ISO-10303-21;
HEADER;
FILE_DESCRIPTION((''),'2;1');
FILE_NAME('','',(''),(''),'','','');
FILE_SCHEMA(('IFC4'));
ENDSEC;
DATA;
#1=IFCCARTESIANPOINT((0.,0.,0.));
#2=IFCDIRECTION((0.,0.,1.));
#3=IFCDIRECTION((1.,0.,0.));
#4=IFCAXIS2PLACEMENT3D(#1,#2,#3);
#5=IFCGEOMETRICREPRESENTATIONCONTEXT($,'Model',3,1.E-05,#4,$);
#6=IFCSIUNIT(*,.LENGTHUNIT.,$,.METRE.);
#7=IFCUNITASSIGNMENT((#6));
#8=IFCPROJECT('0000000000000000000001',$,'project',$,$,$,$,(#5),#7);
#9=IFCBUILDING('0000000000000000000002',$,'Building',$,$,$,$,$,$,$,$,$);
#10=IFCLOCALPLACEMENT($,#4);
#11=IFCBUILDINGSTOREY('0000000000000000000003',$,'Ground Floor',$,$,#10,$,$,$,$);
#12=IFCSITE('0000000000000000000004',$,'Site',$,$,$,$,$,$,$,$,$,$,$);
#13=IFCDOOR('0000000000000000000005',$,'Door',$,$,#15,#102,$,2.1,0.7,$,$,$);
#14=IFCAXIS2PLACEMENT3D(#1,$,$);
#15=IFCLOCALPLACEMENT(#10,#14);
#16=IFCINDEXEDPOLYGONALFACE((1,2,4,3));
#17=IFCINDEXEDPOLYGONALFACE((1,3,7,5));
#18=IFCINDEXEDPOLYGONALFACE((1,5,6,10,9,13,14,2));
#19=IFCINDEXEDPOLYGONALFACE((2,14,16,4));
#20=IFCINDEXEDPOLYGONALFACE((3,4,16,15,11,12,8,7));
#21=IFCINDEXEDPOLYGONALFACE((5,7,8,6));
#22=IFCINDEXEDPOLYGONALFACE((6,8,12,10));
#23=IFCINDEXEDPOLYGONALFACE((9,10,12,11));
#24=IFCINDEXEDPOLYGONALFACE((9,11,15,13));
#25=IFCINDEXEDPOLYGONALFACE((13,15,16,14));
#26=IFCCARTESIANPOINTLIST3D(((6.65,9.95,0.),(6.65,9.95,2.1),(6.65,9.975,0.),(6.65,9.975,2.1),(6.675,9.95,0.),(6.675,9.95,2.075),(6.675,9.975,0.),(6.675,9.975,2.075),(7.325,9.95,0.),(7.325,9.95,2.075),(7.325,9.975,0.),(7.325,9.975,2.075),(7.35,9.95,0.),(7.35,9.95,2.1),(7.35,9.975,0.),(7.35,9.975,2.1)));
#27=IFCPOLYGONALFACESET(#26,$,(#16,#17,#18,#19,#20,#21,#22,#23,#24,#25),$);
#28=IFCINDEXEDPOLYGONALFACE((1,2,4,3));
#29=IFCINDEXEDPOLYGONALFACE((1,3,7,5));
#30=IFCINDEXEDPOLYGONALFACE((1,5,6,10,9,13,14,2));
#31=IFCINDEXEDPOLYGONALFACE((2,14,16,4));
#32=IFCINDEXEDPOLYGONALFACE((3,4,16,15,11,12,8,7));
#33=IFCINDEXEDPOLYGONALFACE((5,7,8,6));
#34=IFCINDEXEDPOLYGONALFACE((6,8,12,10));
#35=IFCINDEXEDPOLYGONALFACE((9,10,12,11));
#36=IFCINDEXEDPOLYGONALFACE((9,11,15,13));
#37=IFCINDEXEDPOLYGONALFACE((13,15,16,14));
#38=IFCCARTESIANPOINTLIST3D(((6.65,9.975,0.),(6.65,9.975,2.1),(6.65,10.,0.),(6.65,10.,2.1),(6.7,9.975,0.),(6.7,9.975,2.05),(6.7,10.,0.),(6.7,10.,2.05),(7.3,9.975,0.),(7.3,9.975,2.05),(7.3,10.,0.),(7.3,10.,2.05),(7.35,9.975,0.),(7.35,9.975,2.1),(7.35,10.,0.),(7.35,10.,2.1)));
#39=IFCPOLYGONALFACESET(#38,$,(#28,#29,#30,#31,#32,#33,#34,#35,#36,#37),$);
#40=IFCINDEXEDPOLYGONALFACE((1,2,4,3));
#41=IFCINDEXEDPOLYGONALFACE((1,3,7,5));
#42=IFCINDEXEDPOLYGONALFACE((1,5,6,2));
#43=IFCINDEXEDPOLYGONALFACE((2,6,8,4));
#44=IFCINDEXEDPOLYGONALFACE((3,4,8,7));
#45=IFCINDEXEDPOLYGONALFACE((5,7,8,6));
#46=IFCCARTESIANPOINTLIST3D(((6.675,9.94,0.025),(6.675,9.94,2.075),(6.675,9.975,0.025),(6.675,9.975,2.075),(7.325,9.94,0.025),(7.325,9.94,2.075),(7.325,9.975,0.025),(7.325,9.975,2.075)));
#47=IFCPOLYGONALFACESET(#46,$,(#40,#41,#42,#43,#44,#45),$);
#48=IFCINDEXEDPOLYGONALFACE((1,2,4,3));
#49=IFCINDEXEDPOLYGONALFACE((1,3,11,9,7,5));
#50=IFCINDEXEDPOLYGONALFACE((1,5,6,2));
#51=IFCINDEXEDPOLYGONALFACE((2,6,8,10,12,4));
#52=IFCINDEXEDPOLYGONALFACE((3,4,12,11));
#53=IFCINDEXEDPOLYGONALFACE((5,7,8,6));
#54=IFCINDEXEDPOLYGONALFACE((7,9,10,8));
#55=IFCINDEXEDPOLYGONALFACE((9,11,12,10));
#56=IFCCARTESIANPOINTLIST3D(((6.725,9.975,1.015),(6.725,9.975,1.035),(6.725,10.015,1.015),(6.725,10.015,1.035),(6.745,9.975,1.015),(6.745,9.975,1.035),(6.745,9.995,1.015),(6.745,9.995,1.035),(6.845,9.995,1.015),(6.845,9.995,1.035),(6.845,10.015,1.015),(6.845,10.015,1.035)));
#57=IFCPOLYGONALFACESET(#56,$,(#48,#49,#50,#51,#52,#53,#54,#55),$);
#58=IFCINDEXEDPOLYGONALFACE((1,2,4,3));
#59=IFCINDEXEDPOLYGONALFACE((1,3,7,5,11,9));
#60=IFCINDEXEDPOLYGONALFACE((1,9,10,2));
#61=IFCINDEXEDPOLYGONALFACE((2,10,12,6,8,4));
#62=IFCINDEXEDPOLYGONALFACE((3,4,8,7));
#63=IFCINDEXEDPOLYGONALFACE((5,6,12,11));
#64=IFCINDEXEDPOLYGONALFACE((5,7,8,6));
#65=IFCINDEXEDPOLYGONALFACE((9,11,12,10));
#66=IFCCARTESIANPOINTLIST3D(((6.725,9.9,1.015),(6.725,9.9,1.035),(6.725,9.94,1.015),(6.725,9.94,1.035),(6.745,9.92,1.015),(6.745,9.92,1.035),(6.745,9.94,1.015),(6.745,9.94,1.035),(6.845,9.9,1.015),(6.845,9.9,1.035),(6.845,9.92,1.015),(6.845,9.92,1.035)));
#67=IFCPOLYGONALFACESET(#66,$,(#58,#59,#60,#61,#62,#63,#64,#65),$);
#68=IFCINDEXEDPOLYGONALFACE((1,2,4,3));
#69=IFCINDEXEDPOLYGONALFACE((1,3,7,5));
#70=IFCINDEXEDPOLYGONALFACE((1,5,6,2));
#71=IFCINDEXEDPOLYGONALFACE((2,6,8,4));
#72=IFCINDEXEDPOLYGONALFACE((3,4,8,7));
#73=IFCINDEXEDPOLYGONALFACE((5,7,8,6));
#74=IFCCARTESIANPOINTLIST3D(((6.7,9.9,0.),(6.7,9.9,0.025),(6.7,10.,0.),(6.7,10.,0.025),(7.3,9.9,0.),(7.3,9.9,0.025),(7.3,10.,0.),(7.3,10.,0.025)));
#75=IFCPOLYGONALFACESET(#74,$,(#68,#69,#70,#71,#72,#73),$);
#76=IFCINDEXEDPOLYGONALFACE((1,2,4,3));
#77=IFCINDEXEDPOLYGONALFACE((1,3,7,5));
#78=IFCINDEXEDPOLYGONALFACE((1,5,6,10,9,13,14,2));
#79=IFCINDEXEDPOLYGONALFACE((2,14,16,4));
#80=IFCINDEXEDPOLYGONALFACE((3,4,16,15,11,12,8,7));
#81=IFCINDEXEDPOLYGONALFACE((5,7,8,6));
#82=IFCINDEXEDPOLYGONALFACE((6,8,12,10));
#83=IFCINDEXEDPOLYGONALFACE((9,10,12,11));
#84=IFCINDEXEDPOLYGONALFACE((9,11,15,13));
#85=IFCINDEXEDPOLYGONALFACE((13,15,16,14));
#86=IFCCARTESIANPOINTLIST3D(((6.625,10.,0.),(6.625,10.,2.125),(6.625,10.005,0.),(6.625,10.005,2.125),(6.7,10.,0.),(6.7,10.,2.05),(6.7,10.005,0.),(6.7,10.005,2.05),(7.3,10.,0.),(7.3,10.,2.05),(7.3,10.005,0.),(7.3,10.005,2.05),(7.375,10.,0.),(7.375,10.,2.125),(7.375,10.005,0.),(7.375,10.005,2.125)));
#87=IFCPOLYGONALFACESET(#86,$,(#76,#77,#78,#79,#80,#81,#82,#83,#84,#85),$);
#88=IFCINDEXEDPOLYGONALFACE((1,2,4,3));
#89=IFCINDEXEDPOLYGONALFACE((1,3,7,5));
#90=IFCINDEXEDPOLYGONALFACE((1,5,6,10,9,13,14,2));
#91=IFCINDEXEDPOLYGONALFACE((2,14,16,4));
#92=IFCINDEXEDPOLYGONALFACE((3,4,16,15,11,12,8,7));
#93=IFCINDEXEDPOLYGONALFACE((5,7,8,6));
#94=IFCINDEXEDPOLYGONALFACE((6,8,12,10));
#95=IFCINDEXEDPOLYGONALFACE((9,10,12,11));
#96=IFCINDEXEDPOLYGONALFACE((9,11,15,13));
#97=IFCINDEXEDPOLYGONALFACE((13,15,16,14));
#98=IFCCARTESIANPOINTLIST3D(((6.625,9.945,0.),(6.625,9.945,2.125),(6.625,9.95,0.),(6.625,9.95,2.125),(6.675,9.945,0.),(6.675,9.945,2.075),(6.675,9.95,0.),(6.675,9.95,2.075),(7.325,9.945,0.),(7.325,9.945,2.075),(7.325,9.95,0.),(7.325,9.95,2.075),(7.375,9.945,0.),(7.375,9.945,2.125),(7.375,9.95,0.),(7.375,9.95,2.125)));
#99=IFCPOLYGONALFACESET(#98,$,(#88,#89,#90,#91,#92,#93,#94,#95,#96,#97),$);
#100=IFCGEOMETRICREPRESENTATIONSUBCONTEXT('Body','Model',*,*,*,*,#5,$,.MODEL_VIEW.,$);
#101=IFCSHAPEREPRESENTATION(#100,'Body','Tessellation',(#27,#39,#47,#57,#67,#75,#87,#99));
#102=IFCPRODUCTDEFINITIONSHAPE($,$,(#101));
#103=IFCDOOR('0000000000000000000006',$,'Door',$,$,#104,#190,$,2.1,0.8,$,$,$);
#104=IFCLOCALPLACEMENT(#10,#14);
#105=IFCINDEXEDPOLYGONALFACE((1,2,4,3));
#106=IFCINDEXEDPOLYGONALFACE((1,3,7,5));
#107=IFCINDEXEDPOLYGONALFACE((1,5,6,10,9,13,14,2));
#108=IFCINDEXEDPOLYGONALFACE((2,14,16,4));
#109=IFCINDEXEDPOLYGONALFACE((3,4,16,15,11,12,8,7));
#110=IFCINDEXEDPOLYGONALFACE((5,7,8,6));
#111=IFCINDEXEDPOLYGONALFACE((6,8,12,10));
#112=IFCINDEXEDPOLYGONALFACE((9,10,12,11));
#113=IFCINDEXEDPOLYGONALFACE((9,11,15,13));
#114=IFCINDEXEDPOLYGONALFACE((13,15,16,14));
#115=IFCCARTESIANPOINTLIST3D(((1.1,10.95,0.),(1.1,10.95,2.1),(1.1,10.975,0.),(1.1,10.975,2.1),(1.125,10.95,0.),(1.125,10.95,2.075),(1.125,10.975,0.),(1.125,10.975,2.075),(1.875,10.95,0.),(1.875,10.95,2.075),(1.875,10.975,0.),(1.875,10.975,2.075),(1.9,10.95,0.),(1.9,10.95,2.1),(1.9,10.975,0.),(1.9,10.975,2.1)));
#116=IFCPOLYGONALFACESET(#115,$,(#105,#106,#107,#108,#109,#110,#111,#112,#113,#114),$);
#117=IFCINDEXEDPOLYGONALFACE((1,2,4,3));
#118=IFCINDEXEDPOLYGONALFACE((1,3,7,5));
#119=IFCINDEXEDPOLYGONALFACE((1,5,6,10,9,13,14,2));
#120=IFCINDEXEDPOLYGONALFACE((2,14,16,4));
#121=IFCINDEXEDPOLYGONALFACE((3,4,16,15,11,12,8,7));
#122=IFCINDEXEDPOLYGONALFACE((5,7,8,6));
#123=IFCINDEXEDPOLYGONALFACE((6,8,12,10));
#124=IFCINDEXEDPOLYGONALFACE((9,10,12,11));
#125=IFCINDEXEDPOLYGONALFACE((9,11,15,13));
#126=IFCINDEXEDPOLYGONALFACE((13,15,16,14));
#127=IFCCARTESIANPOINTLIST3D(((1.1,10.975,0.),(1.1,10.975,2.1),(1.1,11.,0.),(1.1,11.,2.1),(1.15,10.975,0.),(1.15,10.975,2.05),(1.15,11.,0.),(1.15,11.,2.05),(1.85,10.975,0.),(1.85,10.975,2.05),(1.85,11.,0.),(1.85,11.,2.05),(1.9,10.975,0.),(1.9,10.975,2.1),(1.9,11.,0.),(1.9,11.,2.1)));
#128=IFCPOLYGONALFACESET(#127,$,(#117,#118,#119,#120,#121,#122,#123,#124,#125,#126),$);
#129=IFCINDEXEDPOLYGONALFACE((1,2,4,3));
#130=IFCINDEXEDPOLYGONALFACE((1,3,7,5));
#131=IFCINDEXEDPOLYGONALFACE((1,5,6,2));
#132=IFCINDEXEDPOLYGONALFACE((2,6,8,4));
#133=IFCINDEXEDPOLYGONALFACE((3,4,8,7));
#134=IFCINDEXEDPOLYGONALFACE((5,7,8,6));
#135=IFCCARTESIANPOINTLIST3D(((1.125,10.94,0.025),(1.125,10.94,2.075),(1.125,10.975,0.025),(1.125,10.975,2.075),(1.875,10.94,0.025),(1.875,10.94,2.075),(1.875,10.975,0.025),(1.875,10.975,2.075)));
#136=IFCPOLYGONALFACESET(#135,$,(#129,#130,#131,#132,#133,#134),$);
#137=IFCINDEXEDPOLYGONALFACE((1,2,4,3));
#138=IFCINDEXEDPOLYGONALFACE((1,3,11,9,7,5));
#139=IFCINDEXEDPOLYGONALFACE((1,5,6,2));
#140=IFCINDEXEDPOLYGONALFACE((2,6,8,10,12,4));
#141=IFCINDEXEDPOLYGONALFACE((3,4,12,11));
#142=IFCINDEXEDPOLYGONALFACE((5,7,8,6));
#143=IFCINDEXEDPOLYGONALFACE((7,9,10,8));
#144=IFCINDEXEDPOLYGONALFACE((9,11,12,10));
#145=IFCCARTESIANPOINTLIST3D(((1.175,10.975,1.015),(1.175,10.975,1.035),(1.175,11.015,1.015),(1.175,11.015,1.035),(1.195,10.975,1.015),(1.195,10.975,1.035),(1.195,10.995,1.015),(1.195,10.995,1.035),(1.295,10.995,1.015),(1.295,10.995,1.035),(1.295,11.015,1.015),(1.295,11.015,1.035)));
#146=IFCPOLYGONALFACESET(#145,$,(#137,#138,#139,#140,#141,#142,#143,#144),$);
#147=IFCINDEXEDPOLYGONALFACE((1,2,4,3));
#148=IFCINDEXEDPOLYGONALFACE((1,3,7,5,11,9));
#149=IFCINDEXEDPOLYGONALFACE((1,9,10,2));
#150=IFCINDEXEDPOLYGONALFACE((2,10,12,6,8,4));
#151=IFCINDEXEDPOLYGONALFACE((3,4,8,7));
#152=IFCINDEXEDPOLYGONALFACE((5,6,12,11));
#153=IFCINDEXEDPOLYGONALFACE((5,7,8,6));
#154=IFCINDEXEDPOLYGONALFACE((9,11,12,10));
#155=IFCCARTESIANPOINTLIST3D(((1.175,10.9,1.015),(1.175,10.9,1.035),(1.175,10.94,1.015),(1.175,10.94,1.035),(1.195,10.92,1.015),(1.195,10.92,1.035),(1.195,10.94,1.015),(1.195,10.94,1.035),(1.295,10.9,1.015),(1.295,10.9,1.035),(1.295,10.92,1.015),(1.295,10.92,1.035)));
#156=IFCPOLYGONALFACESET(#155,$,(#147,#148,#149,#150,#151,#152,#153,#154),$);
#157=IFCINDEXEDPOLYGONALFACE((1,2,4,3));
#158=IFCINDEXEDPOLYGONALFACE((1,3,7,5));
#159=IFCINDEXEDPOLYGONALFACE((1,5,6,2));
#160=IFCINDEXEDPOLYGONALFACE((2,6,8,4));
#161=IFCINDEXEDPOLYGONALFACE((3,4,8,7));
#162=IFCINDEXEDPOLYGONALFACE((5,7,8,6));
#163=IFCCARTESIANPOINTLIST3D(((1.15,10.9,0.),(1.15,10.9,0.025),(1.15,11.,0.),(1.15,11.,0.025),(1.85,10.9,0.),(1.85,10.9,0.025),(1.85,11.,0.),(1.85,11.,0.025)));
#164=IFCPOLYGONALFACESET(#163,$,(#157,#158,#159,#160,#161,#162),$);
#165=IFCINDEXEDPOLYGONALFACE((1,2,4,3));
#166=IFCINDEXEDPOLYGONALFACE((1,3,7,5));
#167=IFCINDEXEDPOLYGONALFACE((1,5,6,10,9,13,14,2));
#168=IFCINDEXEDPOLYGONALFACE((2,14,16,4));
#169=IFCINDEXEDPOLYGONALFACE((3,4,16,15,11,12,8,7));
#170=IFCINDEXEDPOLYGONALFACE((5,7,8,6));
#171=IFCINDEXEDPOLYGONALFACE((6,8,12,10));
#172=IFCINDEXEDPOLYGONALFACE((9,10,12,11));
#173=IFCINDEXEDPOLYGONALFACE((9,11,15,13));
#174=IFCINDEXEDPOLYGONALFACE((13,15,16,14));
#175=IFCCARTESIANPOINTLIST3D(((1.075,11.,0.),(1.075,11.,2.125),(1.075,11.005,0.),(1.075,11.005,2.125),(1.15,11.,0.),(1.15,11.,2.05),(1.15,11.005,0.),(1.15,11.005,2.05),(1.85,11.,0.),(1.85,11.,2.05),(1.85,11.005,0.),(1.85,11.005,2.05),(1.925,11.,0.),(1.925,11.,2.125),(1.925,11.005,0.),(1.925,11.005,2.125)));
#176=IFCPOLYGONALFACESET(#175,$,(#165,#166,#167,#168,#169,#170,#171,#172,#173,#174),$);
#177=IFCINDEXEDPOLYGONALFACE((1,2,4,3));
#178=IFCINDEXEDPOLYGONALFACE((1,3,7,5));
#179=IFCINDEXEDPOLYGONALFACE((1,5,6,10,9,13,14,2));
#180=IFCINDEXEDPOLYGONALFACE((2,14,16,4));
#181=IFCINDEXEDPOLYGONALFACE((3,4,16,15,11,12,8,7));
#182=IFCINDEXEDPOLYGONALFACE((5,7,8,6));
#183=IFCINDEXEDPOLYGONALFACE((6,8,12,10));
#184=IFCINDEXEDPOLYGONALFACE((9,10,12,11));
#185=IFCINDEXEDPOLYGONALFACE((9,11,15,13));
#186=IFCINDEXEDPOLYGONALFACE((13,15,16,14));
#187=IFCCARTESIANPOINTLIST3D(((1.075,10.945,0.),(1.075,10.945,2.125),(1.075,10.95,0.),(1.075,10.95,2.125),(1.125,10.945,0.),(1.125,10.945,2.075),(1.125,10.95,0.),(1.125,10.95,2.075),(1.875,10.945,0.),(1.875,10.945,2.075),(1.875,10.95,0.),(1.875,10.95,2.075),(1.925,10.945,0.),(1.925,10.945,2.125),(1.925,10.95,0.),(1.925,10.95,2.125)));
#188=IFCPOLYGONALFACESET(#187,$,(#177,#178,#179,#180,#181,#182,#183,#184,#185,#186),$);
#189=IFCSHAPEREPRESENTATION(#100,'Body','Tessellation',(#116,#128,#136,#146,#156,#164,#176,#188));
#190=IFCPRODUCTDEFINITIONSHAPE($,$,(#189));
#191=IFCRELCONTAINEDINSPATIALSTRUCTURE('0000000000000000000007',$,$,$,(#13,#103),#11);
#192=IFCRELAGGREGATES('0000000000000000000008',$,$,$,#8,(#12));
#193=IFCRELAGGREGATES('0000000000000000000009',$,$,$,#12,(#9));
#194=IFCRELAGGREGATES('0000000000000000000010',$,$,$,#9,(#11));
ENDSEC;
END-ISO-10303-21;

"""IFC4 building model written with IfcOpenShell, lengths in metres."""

from ifc_helpers import new_model, si_unit, frame, origin_with_axes, place, context, subcontext, project, spatial, line, indexed_curve, outline, extrude, element, save


model = new_model("IFC4")

# Units and contexts
model_context = context("Model", 3, precision=1e-05, world=origin_with_axes())
body_context = subcontext(model_context, "Body", "Model", "MODEL_VIEW")
ifc_project = project(units=[si_unit("LENGTHUNIT", "METRE")], contexts=[model_context])

# Site, building, storey
site = spatial("IfcSite", under=ifc_project, Name="Site")
building = spatial("IfcBuilding", under=site, Name="Building")
storey_placement = place(None, origin_with_axes())
storey = spatial("IfcBuildingStorey", under=building, at=storey_placement, Name="Ground Floor")

# Doors
door_1_placement = place(storey_placement, frame((7.35, 10.0, 0.0), z_axis=(0.0, 0.0, 1.0), x_axis=(-1.0, 0.0, 0.0)))
element("IfcDoor", 1, at=door_1_placement, inside=storey, Name="Door", OverallHeight=2.1, OverallWidth=0.7, context=body_context, shape_type="SweptSolid", body=[
    extrude(outline(indexed_curve([(0.0, 0.0), (0.0, 2.1), (0.7, 2.1), (0.7, 0.0), (0.675, 0.0), (0.675, 2.075), (0.025, 2.075), (0.025, 0.0)], segments=[line(1, 2, 3, 4, 5, 6, 7, 8, 1)])), frame((0.0, 0.025, 0.0), z_axis=(0.0, -1.0, 0.0), x_axis=(1.0, 0.0, 0.0)), (0.0, 0.0, -1.0), 0.025),
    extrude(outline(indexed_curve([(0.0, 0.0), (0.0, 2.1), (0.7, 2.1), (0.7, 0.0), (0.65, 0.0), (0.65, 2.05), (0.05, 2.05), (0.05, 0.0)], segments=[line(1, 2, 3, 4, 5, 6, 7, 8, 1)])), frame((0.0, 0.0, 0.0), z_axis=(0.0, -1.0, 0.0), x_axis=(1.0, 0.0, 0.0)), (0.0, 0.0, -1.0), 0.025),
    extrude(outline(indexed_curve([(0.0, 0.0), (0.65, 0.0), (0.65, 0.035), (0.0, 0.035)], segments=[line(1, 2, 3, 4, 1)])), frame((0.025, 0.025, 0.025), z_axis=(0.0, 0.0, 1.0), x_axis=(1.0, 0.0, 0.0)), (0.0, 0.0, 1.0), 2.05),
    extrude(outline(indexed_curve([(0.0, 0.0), (0.0, -0.04), (-0.12, -0.04), (-0.12, -0.02), (-0.02, -0.02), (-0.02, 0.0)], segments=[line(1, 2, 3, 4, 5, 6, 1)])), frame((0.625, 0.025, 1.015), z_axis=(0.0, 0.0, 1.0), x_axis=(1.0, 0.0, 0.0)), (0.0, 0.0, 1.0), 0.02),
    extrude(outline(indexed_curve([(0.0, 0.0), (0.0, 0.04), (-0.12, 0.04), (-0.12, 0.02), (-0.02, 0.02), (-0.02, 0.0)], segments=[line(1, 2, 3, 4, 5, 6, 1)])), frame((0.625, 0.06, 1.015), z_axis=(0.0, 0.0, 1.0), x_axis=(1.0, 0.0, 0.0)), (0.0, 0.0, 1.0), 0.02),
    extrude(outline(indexed_curve([(0.0, 0.0), (0.6, 0.0), (0.6, 0.1), (0.0, 0.1)], segments=[line(1, 2, 3, 4, 1)])), frame((0.05, 0.0, 0.0), z_axis=(0.0, 0.0, 1.0), x_axis=(1.0, 0.0, 0.0)), (0.0, 0.0, 1.0), 0.025),
    extrude(outline(indexed_curve([(0.0, 0.0), (0.0, 2.125), (0.75, 2.125), (0.75, 0.0), (0.675, 0.0), (0.675, 2.05), (0.075, 2.05), (0.075, 0.0)], segments=[line(1, 2, 3, 4, 5, 6, 7, 8, 1)])), frame((-0.025, -0.005, 0.0), z_axis=(0.0, -1.0, 0.0), x_axis=(1.0, 0.0, 0.0)), (0.0, 0.0, -1.0), 0.005),
    extrude(outline(indexed_curve([(0.0, 0.0), (0.0, 2.125), (0.75, 2.125), (0.75, 0.0), (0.7, 0.0), (0.7, 2.075), (0.05, 2.075), (0.05, 0.0)], segments=[line(1, 2, 3, 4, 5, 6, 7, 8, 1)])), frame((-0.025, 0.05, 0.0), z_axis=(0.0, -1.0, 0.0), x_axis=(1.0, 0.0, 0.0)), (0.0, 0.0, -1.0), 0.005),
])
door_2_placement = place(storey_placement, frame((1.9, 11.0, 0.0), z_axis=(0.0, 0.0, 1.0), x_axis=(-1.0, 0.0, 0.0)))
element("IfcDoor", 2, at=door_2_placement, inside=storey, Name="Door", OverallHeight=2.1, OverallWidth=0.8, context=body_context, shape_type="SweptSolid", body=[
    extrude(outline(indexed_curve([(0.0, 0.0), (0.0, 2.1), (0.8, 2.1), (0.8, 0.0), (0.775, 0.0), (0.775, 2.075), (0.025, 2.075), (0.025, 0.0)], segments=[line(1, 2, 3, 4, 5, 6, 7, 8, 1)])), frame((0.0, 0.025, 0.0), z_axis=(0.0, -1.0, 0.0), x_axis=(1.0, 0.0, 0.0)), (0.0, 0.0, -1.0), 0.025),
    extrude(outline(indexed_curve([(0.0, 0.0), (0.0, 2.1), (0.8, 2.1), (0.8, 0.0), (0.75, 0.0), (0.75, 2.05), (0.05, 2.05), (0.05, 0.0)], segments=[line(1, 2, 3, 4, 5, 6, 7, 8, 1)])), frame((0.0, 0.0, 0.0), z_axis=(0.0, -1.0, 0.0), x_axis=(1.0, 0.0, 0.0)), (0.0, 0.0, -1.0), 0.025),
    extrude(outline(indexed_curve([(0.0, 0.0), (0.75, 0.0), (0.75, 0.035), (0.0, 0.035)], segments=[line(1, 2, 3, 4, 1)])), frame((0.025, 0.025, 0.025), z_axis=(0.0, 0.0, 1.0), x_axis=(1.0, 0.0, 0.0)), (0.0, 0.0, 1.0), 2.05),
    extrude(outline(indexed_curve([(0.0, 0.0), (0.0, -0.04), (-0.12, -0.04), (-0.12, -0.02), (-0.02, -0.02), (-0.02, 0.0)], segments=[line(1, 2, 3, 4, 5, 6, 1)])), frame((0.725, 0.025, 1.015), z_axis=(0.0, 0.0, 1.0), x_axis=(1.0, 0.0, 0.0)), (0.0, 0.0, 1.0), 0.02),
    extrude(outline(indexed_curve([(0.0, 0.0), (0.0, 0.04), (-0.12, 0.04), (-0.12, 0.02), (-0.02, 0.02), (-0.02, 0.0)], segments=[line(1, 2, 3, 4, 5, 6, 1)])), frame((0.725, 0.06, 1.015), z_axis=(0.0, 0.0, 1.0), x_axis=(1.0, 0.0, 0.0)), (0.0, 0.0, 1.0), 0.02),
    extrude(outline(indexed_curve([(0.0, 0.0), (0.7, 0.0), (0.7, 0.1), (0.0, 0.1)], segments=[line(1, 2, 3, 4, 1)])), frame((0.05, 0.0, 0.0), z_axis=(0.0, 0.0, 1.0), x_axis=(1.0, 0.0, 0.0)), (0.0, 0.0, 1.0), 0.025),
    extrude(outline(indexed_curve([(0.0, 0.0), (0.0, 2.125), (0.85, 2.125), (0.85, 0.0), (0.775, 0.0), (0.775, 2.05), (0.075, 2.05), (0.075, 0.0)], segments=[line(1, 2, 3, 4, 5, 6, 7, 8, 1)])), frame((-0.025, -0.005, 0.0), z_axis=(0.0, -1.0, 0.0), x_axis=(1.0, 0.0, 0.0)), (0.0, 0.0, -1.0), 0.005),
    extrude(outline(indexed_curve([(0.0, 0.0), (0.0, 2.125), (0.85, 2.125), (0.85, 0.0), (0.8, 0.0), (0.8, 2.075), (0.05, 2.075), (0.05, 0.0)], segments=[line(1, 2, 3, 4, 5, 6, 7, 8, 1)])), frame((-0.025, 0.05, 0.0), z_axis=(0.0, -1.0, 0.0), x_axis=(1.0, 0.0, 0.0)), (0.0, 0.0, -1.0), 0.005),
])

save(model, "model.ifc")
